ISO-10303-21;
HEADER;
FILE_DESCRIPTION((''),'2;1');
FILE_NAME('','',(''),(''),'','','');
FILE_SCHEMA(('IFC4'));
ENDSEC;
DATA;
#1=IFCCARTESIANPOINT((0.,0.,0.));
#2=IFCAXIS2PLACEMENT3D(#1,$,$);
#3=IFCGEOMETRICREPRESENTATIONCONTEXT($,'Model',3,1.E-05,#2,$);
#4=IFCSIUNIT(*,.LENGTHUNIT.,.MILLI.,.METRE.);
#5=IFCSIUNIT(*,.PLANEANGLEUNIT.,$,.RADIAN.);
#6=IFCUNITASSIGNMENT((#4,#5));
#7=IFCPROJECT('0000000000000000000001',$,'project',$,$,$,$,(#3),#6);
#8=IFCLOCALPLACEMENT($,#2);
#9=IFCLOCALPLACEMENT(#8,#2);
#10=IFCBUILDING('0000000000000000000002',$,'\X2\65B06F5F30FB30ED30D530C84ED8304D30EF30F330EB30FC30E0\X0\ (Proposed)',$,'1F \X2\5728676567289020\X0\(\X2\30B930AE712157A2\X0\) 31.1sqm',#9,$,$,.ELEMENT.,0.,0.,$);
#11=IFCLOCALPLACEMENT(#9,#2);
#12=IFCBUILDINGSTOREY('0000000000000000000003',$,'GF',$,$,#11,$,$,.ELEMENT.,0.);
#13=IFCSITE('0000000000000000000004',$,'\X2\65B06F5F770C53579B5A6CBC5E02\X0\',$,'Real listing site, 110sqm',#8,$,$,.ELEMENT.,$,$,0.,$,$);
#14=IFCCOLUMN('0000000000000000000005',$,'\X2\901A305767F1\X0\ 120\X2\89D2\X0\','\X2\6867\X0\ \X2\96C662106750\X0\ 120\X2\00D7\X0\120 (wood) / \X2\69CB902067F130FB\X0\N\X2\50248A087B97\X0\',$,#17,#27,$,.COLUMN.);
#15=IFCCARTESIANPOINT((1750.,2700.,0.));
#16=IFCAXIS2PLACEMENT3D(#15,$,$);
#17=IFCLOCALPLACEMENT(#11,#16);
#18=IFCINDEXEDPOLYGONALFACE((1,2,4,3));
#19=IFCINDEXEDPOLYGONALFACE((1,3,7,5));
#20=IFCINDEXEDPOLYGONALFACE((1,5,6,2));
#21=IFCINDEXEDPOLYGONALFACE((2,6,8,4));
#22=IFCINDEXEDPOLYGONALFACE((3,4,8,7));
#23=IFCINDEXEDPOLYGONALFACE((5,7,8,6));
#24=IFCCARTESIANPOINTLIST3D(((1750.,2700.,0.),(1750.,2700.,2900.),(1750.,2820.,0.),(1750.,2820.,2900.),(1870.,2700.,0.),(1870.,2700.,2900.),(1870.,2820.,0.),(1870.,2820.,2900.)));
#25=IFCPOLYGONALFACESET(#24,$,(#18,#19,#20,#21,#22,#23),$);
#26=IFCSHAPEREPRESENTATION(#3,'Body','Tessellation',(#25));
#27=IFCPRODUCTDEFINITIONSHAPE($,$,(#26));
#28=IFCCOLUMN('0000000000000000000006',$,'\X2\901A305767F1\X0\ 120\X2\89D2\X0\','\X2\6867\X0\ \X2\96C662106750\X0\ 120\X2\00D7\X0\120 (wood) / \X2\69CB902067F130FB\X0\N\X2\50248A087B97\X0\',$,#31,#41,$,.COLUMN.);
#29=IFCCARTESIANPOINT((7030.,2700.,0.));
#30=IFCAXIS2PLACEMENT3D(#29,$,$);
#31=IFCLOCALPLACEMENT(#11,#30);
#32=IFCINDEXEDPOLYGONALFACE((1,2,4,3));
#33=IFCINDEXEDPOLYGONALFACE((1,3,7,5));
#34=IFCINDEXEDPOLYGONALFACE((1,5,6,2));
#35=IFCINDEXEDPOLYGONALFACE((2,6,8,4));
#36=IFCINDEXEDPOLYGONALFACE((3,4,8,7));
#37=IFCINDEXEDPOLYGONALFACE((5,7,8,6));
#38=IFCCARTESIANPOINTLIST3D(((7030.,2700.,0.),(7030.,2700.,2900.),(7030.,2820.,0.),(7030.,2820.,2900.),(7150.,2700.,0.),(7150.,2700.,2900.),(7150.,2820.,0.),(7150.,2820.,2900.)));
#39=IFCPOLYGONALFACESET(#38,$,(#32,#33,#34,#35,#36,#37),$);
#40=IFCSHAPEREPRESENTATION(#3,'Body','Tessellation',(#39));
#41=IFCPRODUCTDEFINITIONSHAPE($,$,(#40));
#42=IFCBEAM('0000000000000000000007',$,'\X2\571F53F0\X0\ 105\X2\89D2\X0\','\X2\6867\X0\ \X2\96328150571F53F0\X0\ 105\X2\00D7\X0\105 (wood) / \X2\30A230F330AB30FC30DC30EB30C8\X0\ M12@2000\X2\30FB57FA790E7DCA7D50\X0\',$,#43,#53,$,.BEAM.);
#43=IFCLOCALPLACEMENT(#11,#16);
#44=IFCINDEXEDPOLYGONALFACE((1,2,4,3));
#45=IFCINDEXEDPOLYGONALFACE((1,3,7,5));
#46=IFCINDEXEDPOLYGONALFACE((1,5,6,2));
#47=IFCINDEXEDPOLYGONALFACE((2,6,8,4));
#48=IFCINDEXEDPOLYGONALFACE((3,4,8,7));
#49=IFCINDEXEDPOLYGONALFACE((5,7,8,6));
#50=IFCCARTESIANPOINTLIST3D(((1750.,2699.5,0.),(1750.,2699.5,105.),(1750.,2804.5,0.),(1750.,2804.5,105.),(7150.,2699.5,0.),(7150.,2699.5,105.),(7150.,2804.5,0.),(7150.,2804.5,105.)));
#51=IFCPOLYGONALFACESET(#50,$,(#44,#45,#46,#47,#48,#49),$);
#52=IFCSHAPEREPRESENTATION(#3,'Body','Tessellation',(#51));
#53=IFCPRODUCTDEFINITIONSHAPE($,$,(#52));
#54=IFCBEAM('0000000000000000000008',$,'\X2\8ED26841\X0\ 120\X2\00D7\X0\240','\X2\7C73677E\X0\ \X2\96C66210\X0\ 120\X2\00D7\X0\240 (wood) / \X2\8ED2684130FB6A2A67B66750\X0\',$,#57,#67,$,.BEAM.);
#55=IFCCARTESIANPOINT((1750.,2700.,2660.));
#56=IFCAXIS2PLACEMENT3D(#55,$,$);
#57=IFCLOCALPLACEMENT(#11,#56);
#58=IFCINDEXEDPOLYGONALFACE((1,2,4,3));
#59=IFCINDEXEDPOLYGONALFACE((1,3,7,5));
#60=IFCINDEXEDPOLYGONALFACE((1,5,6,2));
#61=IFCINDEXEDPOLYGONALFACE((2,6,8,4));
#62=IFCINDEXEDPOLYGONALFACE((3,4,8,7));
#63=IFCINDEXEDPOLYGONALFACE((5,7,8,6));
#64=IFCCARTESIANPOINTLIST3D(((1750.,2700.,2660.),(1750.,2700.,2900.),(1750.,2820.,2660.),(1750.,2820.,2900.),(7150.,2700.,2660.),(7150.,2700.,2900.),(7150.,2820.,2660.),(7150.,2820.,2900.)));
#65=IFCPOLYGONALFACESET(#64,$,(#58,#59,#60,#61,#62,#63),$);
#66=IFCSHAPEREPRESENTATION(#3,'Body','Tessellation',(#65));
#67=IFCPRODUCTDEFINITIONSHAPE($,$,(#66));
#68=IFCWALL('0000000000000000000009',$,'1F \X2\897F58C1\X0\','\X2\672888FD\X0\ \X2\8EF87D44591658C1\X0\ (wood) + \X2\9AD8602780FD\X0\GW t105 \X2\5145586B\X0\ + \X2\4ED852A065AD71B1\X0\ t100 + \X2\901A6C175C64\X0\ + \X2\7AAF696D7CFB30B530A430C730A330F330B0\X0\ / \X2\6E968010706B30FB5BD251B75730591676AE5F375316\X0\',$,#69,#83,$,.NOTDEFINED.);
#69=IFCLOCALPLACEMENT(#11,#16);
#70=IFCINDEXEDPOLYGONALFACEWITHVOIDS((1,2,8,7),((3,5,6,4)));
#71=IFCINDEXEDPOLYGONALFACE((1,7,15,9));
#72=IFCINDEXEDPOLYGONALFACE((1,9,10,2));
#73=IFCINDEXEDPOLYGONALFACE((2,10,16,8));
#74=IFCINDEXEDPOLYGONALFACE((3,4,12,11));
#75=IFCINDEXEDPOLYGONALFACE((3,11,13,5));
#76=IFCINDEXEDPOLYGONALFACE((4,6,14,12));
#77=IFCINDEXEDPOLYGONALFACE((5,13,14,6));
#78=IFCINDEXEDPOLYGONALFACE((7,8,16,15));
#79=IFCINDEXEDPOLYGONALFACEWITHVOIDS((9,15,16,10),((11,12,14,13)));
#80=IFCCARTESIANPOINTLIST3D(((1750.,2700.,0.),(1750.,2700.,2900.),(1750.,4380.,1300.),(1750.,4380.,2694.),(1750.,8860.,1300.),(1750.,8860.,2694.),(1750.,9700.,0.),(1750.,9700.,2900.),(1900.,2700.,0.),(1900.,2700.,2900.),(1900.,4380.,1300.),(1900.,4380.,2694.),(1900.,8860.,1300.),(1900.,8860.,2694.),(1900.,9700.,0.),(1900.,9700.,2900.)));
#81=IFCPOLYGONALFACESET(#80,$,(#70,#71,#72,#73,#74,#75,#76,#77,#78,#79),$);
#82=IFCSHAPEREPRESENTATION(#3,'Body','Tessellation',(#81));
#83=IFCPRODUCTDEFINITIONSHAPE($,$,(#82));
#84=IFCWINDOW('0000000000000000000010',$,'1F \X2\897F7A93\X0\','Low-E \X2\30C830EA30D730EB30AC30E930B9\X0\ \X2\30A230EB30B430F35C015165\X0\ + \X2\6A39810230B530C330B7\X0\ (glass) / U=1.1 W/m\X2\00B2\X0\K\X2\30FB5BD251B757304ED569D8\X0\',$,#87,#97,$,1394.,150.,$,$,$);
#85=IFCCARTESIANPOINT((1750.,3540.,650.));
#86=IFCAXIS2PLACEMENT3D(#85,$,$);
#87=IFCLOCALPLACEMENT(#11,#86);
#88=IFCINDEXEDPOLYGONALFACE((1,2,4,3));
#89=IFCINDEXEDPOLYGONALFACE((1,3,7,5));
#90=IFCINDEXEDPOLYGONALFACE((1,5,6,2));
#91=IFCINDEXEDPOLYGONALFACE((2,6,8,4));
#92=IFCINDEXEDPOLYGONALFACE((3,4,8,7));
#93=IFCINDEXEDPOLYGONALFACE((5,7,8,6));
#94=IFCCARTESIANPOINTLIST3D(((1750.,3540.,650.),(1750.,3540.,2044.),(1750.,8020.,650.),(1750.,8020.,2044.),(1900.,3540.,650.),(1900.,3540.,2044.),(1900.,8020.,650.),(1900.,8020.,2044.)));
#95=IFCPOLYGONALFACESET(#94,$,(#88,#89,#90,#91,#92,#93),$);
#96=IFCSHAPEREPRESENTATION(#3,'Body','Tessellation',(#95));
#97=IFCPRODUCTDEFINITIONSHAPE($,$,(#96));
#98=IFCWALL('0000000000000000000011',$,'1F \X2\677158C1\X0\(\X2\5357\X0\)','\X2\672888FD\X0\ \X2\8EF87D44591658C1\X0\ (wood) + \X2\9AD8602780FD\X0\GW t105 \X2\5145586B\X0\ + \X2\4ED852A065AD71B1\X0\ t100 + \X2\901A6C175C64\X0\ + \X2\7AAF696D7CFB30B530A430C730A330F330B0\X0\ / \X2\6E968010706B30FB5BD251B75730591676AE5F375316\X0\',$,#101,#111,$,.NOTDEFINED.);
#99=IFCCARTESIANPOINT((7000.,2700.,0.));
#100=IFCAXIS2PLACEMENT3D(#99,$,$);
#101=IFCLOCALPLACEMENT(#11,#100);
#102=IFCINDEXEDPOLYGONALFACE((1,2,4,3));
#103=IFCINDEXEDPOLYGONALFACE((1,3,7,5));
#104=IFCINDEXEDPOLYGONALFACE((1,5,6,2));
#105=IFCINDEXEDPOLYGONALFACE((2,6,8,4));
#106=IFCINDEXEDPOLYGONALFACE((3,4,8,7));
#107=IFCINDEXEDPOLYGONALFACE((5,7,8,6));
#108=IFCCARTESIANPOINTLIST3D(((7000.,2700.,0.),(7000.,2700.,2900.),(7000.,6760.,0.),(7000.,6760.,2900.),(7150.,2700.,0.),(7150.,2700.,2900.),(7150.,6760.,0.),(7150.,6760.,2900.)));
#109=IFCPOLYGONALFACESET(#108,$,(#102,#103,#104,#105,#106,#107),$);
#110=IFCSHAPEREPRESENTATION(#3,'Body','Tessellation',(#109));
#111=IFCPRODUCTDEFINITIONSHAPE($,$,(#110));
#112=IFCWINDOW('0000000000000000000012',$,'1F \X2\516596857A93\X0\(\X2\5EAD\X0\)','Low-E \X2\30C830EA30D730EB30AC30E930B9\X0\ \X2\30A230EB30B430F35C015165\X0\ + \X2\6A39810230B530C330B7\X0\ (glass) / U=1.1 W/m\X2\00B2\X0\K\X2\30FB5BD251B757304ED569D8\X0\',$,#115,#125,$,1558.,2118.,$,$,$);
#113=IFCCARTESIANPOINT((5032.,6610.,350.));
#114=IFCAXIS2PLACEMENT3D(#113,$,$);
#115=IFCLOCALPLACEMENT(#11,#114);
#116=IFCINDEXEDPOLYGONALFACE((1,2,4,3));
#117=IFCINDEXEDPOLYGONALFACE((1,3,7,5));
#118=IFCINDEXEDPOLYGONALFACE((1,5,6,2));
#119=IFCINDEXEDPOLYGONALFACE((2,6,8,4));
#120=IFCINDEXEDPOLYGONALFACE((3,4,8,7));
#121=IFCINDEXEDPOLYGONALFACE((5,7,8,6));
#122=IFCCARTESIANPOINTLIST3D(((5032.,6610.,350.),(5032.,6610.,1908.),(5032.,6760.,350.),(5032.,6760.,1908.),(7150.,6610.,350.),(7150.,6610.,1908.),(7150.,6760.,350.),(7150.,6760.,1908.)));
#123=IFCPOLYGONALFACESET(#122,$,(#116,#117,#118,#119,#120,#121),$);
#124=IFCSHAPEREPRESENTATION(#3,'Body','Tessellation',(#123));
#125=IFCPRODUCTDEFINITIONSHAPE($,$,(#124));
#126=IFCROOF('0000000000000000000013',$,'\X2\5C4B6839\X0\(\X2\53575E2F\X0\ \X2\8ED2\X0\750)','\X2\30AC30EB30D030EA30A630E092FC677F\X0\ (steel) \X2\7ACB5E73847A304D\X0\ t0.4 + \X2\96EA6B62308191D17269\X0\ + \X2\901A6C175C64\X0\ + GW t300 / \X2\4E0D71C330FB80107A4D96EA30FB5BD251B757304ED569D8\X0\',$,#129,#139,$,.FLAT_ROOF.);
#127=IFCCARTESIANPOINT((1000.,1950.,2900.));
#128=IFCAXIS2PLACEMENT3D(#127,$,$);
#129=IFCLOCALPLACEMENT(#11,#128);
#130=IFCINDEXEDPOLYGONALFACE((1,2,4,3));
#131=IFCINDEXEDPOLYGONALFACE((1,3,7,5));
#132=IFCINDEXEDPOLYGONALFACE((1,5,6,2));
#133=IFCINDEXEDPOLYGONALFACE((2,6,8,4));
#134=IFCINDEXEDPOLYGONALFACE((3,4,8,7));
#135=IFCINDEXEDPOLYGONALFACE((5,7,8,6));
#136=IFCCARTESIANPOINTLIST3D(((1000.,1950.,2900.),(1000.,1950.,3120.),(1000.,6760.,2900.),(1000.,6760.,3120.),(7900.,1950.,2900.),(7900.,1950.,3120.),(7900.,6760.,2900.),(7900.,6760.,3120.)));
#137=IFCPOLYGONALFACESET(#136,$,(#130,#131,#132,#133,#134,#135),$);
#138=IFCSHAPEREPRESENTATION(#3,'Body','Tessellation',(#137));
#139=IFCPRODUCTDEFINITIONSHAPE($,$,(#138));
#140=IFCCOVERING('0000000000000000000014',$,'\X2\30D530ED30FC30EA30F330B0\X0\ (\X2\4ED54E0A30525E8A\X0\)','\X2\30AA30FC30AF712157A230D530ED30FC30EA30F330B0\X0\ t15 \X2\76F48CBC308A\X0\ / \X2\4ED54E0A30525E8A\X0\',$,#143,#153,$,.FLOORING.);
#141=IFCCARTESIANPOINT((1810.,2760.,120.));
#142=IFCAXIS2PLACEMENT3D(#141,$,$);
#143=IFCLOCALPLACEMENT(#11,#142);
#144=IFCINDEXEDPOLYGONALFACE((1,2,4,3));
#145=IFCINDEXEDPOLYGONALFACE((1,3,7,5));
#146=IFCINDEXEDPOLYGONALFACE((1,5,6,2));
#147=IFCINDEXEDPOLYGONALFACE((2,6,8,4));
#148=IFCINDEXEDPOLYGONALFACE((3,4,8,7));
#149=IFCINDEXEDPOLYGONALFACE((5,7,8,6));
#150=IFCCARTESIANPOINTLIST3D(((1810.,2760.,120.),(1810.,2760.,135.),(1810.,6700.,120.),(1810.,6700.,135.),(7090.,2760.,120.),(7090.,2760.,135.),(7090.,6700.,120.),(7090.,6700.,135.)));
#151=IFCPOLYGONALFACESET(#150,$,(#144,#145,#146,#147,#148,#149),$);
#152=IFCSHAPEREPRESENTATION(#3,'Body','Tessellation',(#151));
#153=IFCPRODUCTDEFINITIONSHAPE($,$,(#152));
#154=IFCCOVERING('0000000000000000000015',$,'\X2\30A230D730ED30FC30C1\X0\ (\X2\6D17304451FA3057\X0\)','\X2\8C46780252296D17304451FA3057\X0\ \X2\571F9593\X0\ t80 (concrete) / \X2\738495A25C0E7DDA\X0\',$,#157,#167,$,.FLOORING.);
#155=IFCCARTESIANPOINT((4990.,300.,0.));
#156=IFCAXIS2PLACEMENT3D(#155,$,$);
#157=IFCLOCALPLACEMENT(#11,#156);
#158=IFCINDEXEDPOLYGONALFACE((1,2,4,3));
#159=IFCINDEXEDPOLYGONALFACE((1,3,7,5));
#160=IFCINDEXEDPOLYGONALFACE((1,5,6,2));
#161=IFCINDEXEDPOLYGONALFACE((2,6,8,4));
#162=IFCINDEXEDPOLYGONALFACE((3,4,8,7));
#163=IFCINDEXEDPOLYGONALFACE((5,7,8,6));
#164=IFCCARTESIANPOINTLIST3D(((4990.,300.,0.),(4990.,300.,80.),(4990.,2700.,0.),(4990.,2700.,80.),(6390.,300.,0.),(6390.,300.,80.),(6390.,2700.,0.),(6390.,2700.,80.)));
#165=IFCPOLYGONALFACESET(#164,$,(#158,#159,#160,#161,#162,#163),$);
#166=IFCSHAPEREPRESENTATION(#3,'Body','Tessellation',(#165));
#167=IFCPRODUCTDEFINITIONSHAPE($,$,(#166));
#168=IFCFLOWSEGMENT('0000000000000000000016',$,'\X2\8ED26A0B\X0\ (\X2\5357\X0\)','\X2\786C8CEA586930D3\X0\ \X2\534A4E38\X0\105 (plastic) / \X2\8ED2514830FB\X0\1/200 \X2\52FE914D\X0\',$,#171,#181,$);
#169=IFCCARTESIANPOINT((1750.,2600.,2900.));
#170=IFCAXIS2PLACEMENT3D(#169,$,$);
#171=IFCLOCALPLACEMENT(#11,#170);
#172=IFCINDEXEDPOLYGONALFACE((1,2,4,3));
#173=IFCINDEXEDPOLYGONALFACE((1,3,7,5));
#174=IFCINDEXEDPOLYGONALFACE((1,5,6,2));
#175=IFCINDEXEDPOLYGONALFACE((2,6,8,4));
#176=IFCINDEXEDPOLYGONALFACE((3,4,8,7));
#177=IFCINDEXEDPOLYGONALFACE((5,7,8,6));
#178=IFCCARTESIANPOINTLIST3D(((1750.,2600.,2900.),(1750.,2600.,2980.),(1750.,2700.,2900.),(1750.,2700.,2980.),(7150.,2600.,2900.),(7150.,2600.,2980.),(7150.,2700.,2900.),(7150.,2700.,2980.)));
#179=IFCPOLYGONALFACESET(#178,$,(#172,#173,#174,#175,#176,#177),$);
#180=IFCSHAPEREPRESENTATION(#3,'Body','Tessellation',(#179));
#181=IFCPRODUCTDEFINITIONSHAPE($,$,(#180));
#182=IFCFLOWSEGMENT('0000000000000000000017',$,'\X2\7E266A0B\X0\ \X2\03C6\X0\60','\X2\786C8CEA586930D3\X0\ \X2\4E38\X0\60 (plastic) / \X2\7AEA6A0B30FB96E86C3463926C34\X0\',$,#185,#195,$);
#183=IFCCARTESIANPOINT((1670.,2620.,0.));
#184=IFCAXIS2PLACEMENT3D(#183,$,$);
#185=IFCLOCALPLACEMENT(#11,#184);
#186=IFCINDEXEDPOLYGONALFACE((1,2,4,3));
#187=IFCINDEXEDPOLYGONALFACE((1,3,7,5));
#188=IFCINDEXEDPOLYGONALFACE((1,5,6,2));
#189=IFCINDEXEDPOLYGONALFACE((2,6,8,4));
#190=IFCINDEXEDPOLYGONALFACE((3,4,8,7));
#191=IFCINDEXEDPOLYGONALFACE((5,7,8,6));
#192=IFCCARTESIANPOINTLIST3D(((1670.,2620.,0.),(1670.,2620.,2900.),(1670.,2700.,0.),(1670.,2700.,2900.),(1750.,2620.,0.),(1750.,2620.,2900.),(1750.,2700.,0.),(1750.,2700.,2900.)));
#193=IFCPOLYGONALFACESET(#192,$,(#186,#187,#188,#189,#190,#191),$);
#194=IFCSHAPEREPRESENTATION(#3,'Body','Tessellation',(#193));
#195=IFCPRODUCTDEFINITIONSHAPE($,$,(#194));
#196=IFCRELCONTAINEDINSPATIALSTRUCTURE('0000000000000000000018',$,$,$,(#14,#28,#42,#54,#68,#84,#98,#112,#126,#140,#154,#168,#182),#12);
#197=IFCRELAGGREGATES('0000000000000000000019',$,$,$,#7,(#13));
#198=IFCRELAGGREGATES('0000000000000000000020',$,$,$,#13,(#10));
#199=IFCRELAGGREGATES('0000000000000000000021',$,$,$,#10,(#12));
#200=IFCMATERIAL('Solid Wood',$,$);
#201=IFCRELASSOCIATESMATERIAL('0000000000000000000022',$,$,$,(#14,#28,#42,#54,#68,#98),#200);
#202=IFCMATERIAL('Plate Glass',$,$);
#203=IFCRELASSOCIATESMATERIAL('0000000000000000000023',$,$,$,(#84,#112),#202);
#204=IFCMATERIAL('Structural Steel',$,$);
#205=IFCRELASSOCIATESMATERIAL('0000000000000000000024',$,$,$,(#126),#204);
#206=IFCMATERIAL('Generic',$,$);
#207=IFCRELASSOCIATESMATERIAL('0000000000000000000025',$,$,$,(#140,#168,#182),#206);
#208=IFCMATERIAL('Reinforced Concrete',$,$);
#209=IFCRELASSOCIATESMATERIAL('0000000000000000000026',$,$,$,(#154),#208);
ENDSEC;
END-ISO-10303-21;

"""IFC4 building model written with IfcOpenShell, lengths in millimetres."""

from ifc_helpers import new_model, si_unit, frame, frame_2d, origin, place, context, project, spatial, rectangle, extrude, material, element, fill, save


model = new_model("IFC4")

# Units and contexts
model_context = context("Model", 3, precision=1e-05, world=origin())
ifc_project = project(units=[si_unit("LENGTHUNIT", "METRE", prefix="MILLI"), si_unit("PLANEANGLEUNIT", "RADIAN")], contexts=[model_context])

# Site, building, storey
site_placement = place(None, origin())
site = spatial("IfcSite", under=ifc_project, at=site_placement, Name="新潟県南魚沼市", ObjectType="Real listing site, 110sqm", CompositionType="ELEMENT", RefElevation=0.0)
building_placement = place(site_placement, origin())
building = spatial("IfcBuilding", under=site, at=building_placement, Name="新潟・ロフト付きワンルーム (Proposed)", ObjectType="1F 在来木造(スギ無垢) 31.1sqm", CompositionType="ELEMENT", ElevationOfRefHeight=0.0, ElevationOfTerrain=0.0)
storey_placement = place(building_placement, origin())
storey = spatial("IfcBuildingStorey", under=building, at=storey_placement, Name="GF", CompositionType="ELEMENT", Elevation=0.0)

# Columns
ifc_material_1 = material(Name="Solid Wood")
column_1_placement = place(storey_placement, frame((1750.0, 2700.0, 0.0)))
element("IfcColumn", 1, at=column_1_placement, inside=storey, material=ifc_material_1, Name="通し柱 120角", Description="桧 集成材 120×120 (wood) / 構造柱・N値計算", PredefinedType="COLUMN", context=model_context, shape_type="SweptSolid", body=[
    extrude(rectangle(XDim=120.0, YDim=120.0, at=frame_2d((60.0, 60.0))), frame((1750.0, 2700.0, 0.0)), (0.0, 0.0, 1.0), 2900.0),
])
column_2_placement = place(storey_placement, frame((7030.0, 2700.0, 0.0)))
element("IfcColumn", 2, at=column_2_placement, inside=storey, material=ifc_material_1, Name="通し柱 120角", Description="桧 集成材 120×120 (wood) / 構造柱・N値計算", PredefinedType="COLUMN", context=model_context, shape_type="SweptSolid", body=[
    extrude(rectangle(XDim=120.0, YDim=120.0, at=frame_2d((60.0, 60.0))), frame((7030.0, 2700.0, 0.0)), (0.0, 0.0, 1.0), 2900.0),
])

# Beams
beam_1_placement = place(storey_placement, frame((1750.0, 2700.0, 0.0)))
element("IfcBeam", 3, at=beam_1_placement, inside=storey, material=ifc_material_1, Name="土台 105角", Description="桧 防腐土台 105×105 (wood) / アンカーボルト M12@2000・基礎緊結", PredefinedType="BEAM", context=model_context, shape_type="SweptSolid", body=[
    extrude(rectangle(XDim=5400.0, YDim=105.0, at=frame_2d((2700.0, 52.0))), frame((1750.0, 2700.0, 0.0)), (0.0, 0.0, 1.0), 105.0),
])
beam_2_placement = place(storey_placement, frame((1750.0, 2700.0, 2660.0)))
element("IfcBeam", 4, at=beam_2_placement, inside=storey, material=ifc_material_1, Name="軒桁 120×240", Description="米松 集成 120×240 (wood) / 軒桁・横架材", PredefinedType="BEAM", context=model_context, shape_type="SweptSolid", body=[
    extrude(rectangle(XDim=5400.0, YDim=120.0, at=frame_2d((2700.0, 60.0))), frame((1750.0, 2700.0, 2660.0)), (0.0, 0.0, 1.0), 240.0),
])

# Shared definitions
ifc_material_2 = material(Name="Reinforced Concrete")

# Shared definitions
ifc_material_3 = material(Name="Plate Glass")

# Walls, openings, windows
wall_1_placement = place(storey_placement, frame((1750.0, 2700.0, 0.0)))
wall_1 = element("IfcWall", 5, at=wall_1_placement, inside=storey, material=ifc_material_1, Name="1F 西壁", Description="木製 軸組外壁 (wood) + 高性能GW t105 充填 + 付加断熱 t100 + 通気層 + 窯業系サイディング / 準耐火・寒冷地外皮強化", PredefinedType="NOTDEFINED", context=model_context, shape_type="SweptSolid", body=[
    extrude(rectangle(XDim=150.0, YDim=7000.0, at=frame_2d((75.0, 3500.0))), frame((1750.0, 2700.0, 0.0)), (0.0, 0.0, 1.0), 2900.0),
])
opening_1_placement = place(storey_placement, frame((1750.0, 3540.0, 650.0)))
opening_1 = element("IfcOpeningElement", 6, at=opening_1_placement, cuts=wall_1, PredefinedType="NOTDEFINED", context=model_context, shape_type="SweptSolid", body=[
    extrude(rectangle(XDim=150.0, YDim=4480.0, at=frame_2d((75.0, 2240.0))), frame((1750.0, 3540.0, 650.0)), (0.0, 0.0, 1.0), 1394.0),
])
window_1_placement = place(storey_placement, frame((1750.0, 3540.0, 650.0)))
window_1 = element("IfcWindow", 7, at=window_1_placement, inside=storey, material=ifc_material_3, Name="1F 西窓", Description="Low-E トリプルガラス アルゴン封入 + 樹脂サッシ (glass) / U=1.1 W/m²K・寒冷地仕様", OverallHeight=1394.0, OverallWidth=150.0, context=model_context, shape_type="SweptSolid", body=[
    extrude(rectangle(XDim=150.0, YDim=4480.0, at=frame_2d((75.0, 2240.0))), frame((1750.0, 3540.0, 650.0)), (0.0, 0.0, 1.0), 1394.0),
])
fill(opening_1, window_1)
wall_2_placement = place(storey_placement, frame((7000.0, 2700.0, 0.0)))
wall_2 = element("IfcWall", 8, at=wall_2_placement, inside=storey, material=ifc_material_1, Name="1F 東壁(南)", Description="木製 軸組外壁 (wood) + 高性能GW t105 充填 + 付加断熱 t100 + 通気層 + 窯業系サイディング / 準耐火・寒冷地外皮強化", PredefinedType="NOTDEFINED", context=model_context, shape_type="SweptSolid", body=[
    extrude(rectangle(XDim=150.0, YDim=4060.0, at=frame_2d((75.0, 2030.0))), frame((7000.0, 2700.0, 0.0)), (0.0, 0.0, 1.0), 2900.0),
])
opening_2_placement = place(storey_placement, frame((5032.0, 6610.0, 350.0)))
opening_2 = element("IfcOpeningElement", 9, at=opening_2_placement, cuts=wall_2, PredefinedType="NOTDEFINED", context=model_context, shape_type="SweptSolid", body=[
    extrude(rectangle(XDim=2118.0, YDim=150.0, at=frame_2d((1059.0, 75.0))), frame((5032.0, 6610.0, 350.0)), (0.0, 0.0, 1.0), 1558.0),
])
window_2_placement = place(storey_placement, frame((5032.0, 6610.0, 350.0)))
window_2 = element("IfcWindow", 10, at=window_2_placement, inside=storey, material=ifc_material_3, Name="1F 入隅窓(庭)", Description="Low-E トリプルガラス アルゴン封入 + 樹脂サッシ (glass) / U=1.1 W/m²K・寒冷地仕様", OverallHeight=1558.0, OverallWidth=2118.0, context=model_context, shape_type="SweptSolid", body=[
    extrude(rectangle(XDim=2118.0, YDim=150.0, at=frame_2d((1059.0, 75.0))), frame((5032.0, 6610.0, 350.0)), (0.0, 0.0, 1.0), 1558.0),
])
fill(opening_2, window_2)

# Roof
ifc_material_4 = material(Name="Structural Steel")
roof_placement = place(storey_placement, frame((1000.0, 1950.0, 2900.0)))
element("IfcRoof", 11, at=roof_placement, inside=storey, material=ifc_material_4, Name="屋根(南帯 軒750)", Description="ガルバリウム鋼板 (steel) 立平葺き t0.4 + 雪止め金物 + 通気層 + GW t300 / 不燃・耐積雪・寒冷地仕様", PredefinedType="FLAT_ROOF", context=model_context, shape_type="SweptSolid", body=[
    extrude(rectangle(XDim=6900.0, YDim=4810.0, at=frame_2d((3450.0, 2405.0))), frame((1000.0, 1950.0, 2900.0)), (0.0, 0.0, 1.0), 220.0),
])

# Coverings
ifc_material_5 = material(Name="Generic")
covering_1_placement = place(storey_placement, frame((1810.0, 2760.0, 120.0)))
element("IfcCovering", 12, at=covering_1_placement, inside=storey, material=ifc_material_5, Name="フローリング (仕上げ床)", Description="オーク無垢フローリング t15 直貼り / 仕上げ床", PredefinedType="FLOORING", context=model_context, shape_type="SweptSolid", body=[
    extrude(rectangle(XDim=5280.0, YDim=3940.0, at=frame_2d((2640.0, 1970.0))), frame((1810.0, 2760.0, 120.0)), (0.0, 0.0, 1.0), 15.0),
])
covering_2_placement = place(storey_placement, frame((4990.0, 300.0, 0.0)))
element("IfcCovering", 13, at=covering_2_placement, inside=storey, material=ifc_material_2, Name="アプローチ (洗い出し)", Description="豆砂利洗い出し 土間 t80 (concrete) / 玄関導線", PredefinedType="FLOORING", context=model_context, shape_type="SweptSolid", body=[
    extrude(rectangle(XDim=1400.0, YDim=2400.0, at=frame_2d((700.0, 1200.0))), frame((4990.0, 300.0, 0.0)), (0.0, 0.0, 1.0), 80.0),
])

# Flow segments
flow_segment_1_placement = place(storey_placement, frame((1750.0, 2600.0, 2900.0)))
element("IfcFlowSegment", 14, at=flow_segment_1_placement, inside=storey, material=ifc_material_5, Name="軒樋 (南)", Description="硬質塩ビ 半丸105 (plastic) / 軒先・1/200 勾配", context=model_context, shape_type="SweptSolid", body=[
    extrude(rectangle(XDim=5400.0, YDim=100.0, at=frame_2d((2700.0, 50.0))), frame((1750.0, 2600.0, 2900.0)), (0.0, 0.0, 1.0), 80.0),
])
flow_segment_2_placement = place(storey_placement, frame((1670.0, 2620.0, 0.0)))
element("IfcFlowSegment", 15, at=flow_segment_2_placement, inside=storey, material=ifc_material_5, Name="縦樋 φ60", Description="硬質塩ビ 丸60 (plastic) / 竪樋・雨水排水", context=model_context, shape_type="SweptSolid", body=[
    extrude(rectangle(XDim=80.0, YDim=80.0, at=frame_2d((40.0, 40.0))), frame((1670.0, 2620.0, 0.0)), (0.0, 0.0, 1.0), 2900.0),
])

save(model, "model.ifc")
